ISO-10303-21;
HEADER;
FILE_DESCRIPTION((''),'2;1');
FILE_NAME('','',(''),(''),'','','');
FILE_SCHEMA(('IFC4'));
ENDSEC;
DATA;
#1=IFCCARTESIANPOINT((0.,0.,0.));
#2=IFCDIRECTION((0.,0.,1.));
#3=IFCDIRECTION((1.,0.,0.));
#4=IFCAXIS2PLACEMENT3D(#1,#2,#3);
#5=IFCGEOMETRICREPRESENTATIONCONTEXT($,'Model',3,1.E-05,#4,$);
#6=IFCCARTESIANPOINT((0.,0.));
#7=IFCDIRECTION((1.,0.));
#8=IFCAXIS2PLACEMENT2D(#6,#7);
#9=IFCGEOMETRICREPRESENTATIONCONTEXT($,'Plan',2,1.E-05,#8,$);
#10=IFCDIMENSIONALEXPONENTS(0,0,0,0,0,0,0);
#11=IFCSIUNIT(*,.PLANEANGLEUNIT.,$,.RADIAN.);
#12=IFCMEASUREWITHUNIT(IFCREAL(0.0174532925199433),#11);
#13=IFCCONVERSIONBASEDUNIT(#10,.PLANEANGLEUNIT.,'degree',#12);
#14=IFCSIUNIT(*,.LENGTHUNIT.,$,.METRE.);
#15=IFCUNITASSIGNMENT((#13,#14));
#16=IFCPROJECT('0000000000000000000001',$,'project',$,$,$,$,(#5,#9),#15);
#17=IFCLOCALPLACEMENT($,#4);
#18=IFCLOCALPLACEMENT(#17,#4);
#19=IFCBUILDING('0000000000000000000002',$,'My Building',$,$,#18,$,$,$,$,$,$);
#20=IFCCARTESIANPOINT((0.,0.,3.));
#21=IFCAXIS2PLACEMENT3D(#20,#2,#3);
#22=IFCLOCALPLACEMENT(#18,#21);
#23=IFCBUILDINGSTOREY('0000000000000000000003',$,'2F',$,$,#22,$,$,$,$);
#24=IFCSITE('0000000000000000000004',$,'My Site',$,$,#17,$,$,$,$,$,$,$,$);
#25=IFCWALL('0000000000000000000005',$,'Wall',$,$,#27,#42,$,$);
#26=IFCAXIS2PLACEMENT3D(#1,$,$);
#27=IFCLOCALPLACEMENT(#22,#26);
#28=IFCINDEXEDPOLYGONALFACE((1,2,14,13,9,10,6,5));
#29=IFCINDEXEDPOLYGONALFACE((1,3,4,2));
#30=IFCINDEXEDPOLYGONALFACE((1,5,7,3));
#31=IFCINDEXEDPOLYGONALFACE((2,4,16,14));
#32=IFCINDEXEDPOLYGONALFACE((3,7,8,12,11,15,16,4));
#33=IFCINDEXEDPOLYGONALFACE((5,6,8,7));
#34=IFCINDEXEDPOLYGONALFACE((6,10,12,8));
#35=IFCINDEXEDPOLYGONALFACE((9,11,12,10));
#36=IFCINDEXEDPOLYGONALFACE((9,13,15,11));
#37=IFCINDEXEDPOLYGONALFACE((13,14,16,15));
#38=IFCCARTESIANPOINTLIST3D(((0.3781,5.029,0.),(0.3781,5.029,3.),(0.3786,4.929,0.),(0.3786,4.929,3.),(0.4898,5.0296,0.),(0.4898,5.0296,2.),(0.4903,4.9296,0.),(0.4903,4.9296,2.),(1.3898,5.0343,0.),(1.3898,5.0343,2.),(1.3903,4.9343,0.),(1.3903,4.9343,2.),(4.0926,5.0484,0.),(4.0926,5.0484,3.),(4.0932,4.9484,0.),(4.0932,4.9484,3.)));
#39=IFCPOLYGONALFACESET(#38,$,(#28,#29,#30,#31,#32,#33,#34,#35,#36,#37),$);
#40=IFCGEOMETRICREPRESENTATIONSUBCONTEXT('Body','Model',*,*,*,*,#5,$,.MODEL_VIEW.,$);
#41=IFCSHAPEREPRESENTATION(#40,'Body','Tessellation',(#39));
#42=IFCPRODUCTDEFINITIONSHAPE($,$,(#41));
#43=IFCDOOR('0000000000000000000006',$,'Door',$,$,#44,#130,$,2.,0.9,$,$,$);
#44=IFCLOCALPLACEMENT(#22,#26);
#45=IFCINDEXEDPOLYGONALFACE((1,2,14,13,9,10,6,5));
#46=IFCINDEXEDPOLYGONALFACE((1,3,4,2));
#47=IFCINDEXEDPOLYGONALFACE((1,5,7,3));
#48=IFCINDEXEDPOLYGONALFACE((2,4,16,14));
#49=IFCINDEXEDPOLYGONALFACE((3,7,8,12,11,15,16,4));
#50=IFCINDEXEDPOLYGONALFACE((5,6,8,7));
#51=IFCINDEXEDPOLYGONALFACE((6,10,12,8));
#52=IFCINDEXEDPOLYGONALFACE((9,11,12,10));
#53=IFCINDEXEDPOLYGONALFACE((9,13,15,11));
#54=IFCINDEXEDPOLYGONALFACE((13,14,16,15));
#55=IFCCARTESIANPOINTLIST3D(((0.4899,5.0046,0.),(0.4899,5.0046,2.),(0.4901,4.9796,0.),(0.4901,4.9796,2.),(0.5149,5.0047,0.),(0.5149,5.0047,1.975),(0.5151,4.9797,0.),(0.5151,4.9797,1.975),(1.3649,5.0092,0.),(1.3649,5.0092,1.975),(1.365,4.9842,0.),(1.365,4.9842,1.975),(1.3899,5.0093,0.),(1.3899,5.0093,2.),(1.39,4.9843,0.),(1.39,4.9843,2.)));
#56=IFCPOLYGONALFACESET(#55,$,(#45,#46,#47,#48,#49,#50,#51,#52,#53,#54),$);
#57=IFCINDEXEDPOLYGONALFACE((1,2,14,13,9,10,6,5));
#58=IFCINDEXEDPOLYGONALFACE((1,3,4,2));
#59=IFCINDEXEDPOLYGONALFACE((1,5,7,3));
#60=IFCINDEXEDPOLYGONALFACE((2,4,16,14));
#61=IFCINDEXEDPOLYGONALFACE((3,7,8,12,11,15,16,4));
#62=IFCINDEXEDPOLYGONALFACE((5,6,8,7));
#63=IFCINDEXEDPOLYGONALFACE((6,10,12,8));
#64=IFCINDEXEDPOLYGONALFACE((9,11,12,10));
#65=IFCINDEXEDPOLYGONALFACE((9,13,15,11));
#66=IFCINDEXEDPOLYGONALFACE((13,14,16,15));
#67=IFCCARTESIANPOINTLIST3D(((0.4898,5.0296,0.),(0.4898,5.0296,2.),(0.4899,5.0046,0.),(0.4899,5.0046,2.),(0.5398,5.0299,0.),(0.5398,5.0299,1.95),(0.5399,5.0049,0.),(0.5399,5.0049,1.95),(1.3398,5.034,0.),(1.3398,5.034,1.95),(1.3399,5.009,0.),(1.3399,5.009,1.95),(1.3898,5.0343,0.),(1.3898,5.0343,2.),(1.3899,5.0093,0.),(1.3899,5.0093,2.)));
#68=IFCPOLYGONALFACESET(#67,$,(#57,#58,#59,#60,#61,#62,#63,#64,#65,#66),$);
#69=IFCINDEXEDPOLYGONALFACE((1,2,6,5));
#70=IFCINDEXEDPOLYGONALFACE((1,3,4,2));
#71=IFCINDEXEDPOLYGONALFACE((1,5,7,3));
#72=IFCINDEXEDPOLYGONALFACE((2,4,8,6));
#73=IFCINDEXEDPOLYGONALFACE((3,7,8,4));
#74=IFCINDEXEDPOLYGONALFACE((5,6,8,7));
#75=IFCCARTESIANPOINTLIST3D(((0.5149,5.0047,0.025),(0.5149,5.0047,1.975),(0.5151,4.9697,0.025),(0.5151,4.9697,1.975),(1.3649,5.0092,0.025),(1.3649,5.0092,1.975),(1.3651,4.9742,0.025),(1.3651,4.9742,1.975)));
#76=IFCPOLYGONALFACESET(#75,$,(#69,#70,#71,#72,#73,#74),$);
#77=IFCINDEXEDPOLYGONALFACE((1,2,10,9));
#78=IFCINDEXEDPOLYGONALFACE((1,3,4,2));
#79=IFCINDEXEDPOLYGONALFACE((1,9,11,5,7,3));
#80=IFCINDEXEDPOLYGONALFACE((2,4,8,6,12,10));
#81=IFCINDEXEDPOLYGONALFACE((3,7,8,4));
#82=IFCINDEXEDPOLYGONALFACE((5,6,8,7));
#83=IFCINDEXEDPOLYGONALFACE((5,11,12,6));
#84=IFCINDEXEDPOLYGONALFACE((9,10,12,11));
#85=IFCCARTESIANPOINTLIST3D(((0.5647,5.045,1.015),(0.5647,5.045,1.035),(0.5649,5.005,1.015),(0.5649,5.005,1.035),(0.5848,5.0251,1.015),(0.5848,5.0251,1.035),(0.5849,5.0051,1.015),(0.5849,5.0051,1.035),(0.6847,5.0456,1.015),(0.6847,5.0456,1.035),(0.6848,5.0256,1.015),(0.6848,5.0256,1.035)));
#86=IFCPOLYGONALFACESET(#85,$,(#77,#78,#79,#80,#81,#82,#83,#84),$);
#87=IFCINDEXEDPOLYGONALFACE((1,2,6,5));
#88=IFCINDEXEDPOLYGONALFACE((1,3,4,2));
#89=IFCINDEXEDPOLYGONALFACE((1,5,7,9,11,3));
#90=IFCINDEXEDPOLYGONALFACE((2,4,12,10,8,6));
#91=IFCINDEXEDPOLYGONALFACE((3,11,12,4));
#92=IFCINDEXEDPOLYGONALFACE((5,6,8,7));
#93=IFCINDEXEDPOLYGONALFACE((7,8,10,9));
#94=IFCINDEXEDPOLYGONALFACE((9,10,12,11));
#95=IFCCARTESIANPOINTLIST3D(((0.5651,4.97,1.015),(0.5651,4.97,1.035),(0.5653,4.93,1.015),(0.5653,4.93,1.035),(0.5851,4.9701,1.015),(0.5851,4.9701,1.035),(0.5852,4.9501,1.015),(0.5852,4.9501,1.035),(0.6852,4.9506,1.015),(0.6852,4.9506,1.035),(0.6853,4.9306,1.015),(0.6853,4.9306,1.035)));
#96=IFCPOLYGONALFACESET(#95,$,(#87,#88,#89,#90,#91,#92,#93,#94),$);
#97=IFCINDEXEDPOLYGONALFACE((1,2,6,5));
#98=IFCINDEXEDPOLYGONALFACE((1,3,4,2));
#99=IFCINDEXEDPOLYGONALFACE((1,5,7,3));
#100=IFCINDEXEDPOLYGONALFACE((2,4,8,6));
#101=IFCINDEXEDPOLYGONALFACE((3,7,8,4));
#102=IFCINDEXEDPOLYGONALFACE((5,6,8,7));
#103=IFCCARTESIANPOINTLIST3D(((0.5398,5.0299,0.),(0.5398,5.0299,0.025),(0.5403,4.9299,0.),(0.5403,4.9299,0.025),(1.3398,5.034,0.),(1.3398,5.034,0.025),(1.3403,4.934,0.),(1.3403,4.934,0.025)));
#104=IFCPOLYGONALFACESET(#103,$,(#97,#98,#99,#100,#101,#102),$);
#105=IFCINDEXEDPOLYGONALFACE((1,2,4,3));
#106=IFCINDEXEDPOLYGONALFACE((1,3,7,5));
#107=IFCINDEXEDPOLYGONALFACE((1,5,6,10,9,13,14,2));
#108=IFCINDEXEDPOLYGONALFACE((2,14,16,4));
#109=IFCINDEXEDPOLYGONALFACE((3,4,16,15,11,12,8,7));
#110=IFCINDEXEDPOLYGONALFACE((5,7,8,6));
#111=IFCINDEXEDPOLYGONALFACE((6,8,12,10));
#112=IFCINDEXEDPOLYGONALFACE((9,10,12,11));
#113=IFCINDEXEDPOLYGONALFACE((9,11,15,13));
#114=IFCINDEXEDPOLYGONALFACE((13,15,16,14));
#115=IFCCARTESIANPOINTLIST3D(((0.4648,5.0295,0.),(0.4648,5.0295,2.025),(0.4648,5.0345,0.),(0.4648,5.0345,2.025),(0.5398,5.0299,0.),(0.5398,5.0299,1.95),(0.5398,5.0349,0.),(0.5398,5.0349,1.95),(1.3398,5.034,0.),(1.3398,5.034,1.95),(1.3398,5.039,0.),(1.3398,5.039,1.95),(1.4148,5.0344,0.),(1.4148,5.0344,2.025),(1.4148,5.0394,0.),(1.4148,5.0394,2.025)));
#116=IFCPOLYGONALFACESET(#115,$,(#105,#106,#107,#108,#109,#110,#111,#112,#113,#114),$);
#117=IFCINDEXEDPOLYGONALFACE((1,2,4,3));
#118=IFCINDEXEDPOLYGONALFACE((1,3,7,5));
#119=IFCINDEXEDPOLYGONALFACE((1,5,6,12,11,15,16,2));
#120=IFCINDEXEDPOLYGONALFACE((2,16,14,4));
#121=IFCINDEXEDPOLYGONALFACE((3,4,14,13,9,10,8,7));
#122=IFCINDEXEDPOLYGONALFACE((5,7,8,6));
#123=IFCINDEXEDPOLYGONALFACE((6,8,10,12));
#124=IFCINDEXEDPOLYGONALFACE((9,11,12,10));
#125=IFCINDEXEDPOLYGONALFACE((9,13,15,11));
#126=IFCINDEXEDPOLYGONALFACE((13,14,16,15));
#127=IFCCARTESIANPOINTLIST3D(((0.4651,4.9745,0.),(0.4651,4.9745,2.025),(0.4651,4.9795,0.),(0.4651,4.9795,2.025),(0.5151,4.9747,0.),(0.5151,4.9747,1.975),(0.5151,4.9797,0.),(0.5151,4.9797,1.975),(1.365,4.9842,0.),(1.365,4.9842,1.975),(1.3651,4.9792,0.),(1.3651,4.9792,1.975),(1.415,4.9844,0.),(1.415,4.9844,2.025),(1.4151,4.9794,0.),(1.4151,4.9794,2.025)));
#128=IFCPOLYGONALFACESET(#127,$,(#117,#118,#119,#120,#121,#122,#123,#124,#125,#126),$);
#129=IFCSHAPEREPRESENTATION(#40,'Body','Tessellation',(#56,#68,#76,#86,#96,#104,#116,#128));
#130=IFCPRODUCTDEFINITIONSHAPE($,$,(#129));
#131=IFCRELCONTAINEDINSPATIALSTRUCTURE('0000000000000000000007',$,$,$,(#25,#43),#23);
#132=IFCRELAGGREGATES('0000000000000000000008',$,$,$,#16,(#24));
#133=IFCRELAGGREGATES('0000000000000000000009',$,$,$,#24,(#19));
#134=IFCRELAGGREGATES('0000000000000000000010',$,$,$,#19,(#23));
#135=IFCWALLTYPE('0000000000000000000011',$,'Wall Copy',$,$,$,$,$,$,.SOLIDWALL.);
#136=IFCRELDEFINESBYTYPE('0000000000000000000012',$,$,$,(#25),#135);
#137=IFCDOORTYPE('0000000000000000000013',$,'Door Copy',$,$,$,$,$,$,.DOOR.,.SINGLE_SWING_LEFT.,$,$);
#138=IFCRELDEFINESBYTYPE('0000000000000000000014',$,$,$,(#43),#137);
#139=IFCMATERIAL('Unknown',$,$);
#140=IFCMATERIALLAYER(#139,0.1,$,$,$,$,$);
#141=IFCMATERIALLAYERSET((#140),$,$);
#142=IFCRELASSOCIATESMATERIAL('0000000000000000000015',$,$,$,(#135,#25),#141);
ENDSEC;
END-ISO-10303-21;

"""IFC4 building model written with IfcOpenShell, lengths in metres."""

from ifc_helpers import new_model, entity, si_unit, converted_unit, frame, origin_with_axes, origin_2d_with_axis, place, context, subcontext, project, spatial, line, indexed_curve, outline, extrude, shape, source, transform, mapped, material, layer, layer_set, layer_usage, type_object, type_shapes, element, fill, save


model = new_model("IFC4")

# Units and contexts
model_context = context("Model", 3, precision=1e-05, world=origin_with_axes())
plan_context = context("Plan", 2, precision=1e-05, world=origin_2d_with_axis())
body_context_1 = subcontext(model_context, "Body", "Model", "MODEL_VIEW")
body_context_2 = subcontext(plan_context, "Body", "Plan", "PLAN_VIEW")
ifc_project = project(units=[converted_unit("PLANEANGLEUNIT", "degree", entity("IfcReal", 0.0174532925199433), si_unit("PLANEANGLEUNIT", "RADIAN"), dimensions=[0, 0, 0, 0, 0, 0, 0]), si_unit("LENGTHUNIT", "METRE")], contexts=[model_context, plan_context])

# Site, building, storey
site_placement = place(None, origin_with_axes())
site = spatial("IfcSite", under=ifc_project, at=site_placement, Name="My Site")
building_placement = place(site_placement, origin_with_axes())
building = spatial("IfcBuilding", under=site, at=building_placement, Name="My Building")
storey_placement = place(building_placement, frame((0.0, 0.0, 3.0), z_axis=(0.0, 0.0, 1.0), x_axis=(1.0, 0.0, 0.0)))
storey = spatial("IfcBuildingStorey", under=building, at=storey_placement, Name="2F")

# Shared definitions
ifc_material = material(Name="Unknown")
ifc_layer_1 = layer(ifc_material, 0.1)
ifc_layer_set_1 = layer_set([ifc_layer_1])
wall_type_1 = type_object("IfcWallType", Name="Wall Copy", PredefinedType="SOLIDWALL", material=ifc_layer_set_1)

# Shared definitions
shared_shape_1 = source(origin_with_axes(), body_context_1, "Body", "SweptSolid", [
    extrude(outline(indexed_curve([(0.0, 0.0), (0.9, 0.0), (0.9, 2.0), (0.0, 2.0)], segments=[line(1, 2, 3, 4, 1)])), frame((0.0, -0.6, 0.0), z_axis=(0.0, -1.0, 0.0), x_axis=(1.0, 0.0, 0.0)), (0.0, 0.0, -1.0), 1.2),
])
door_type = type_object("IfcDoorType", Name="Door Copy", OperationType="SINGLE_SWING_LEFT", PredefinedType="DOOR")
shared_shape_2 = source(origin_with_axes(), body_context_1, "Body", "SweptSolid", [
    extrude(outline(indexed_curve([(0.0, 0.0), (0.0, 2.0), (0.9, 2.0), (0.9, 0.0), (0.875, 0.0), (0.875, 1.975), (0.025, 1.975), (0.025, 0.0)], segments=[line(1, 2, 3, 4, 5, 6, 7, 8, 1)])), frame((0.0, 0.025, 0.0), z_axis=(0.0, -1.0, 0.0), x_axis=(1.0, 0.0, 0.0)), (0.0, 0.0, -1.0), 0.025),
    extrude(outline(indexed_curve([(0.0, 0.0), (0.0, 2.0), (0.9, 2.0), (0.9, 0.0), (0.85, 0.0), (0.85, 1.95), (0.05, 1.95), (0.05, 0.0)], segments=[line(1, 2, 3, 4, 5, 6, 7, 8, 1)])), frame((0.0, 0.0, 0.0), z_axis=(0.0, -1.0, 0.0), x_axis=(1.0, 0.0, 0.0)), (0.0, 0.0, -1.0), 0.025),
    extrude(outline(indexed_curve([(0.0, 0.0), (0.85, 0.0), (0.85, 0.035), (0.0, 0.035)], segments=[line(1, 2, 3, 4, 1)])), frame((0.025, 0.025, 0.025), z_axis=(0.0, 0.0, 1.0), x_axis=(1.0, 0.0, 0.0)), (0.0, 0.0, 1.0), 1.95),
    extrude(outline(indexed_curve([(0.0, 0.0), (0.0, -0.04), (-0.12, -0.04), (-0.12, -0.02), (-0.02, -0.02), (-0.02, 0.0)], segments=[line(1, 2, 3, 4, 5, 6, 1)])), frame((0.825, 0.025, 1.015), z_axis=(0.0, 0.0, 1.0), x_axis=(1.0, 0.0, 0.0)), (0.0, 0.0, 1.0), 0.02),
    extrude(outline(indexed_curve([(0.0, 0.0), (0.0, 0.04), (-0.12, 0.04), (-0.12, 0.02), (-0.02, 0.02), (-0.02, 0.0)], segments=[line(1, 2, 3, 4, 5, 6, 1)])), frame((0.825, 0.06, 1.015), z_axis=(0.0, 0.0, 1.0), x_axis=(1.0, 0.0, 0.0)), (0.0, 0.0, 1.0), 0.02),
    extrude(outline(indexed_curve([(0.0, 0.0), (0.8, 0.0), (0.8, 0.1), (0.0, 0.1)], segments=[line(1, 2, 3, 4, 1)])), frame((0.05, 0.0, 0.0), z_axis=(0.0, 0.0, 1.0), x_axis=(1.0, 0.0, 0.0)), (0.0, 0.0, 1.0), 0.025),
    extrude(outline(indexed_curve([(0.0, 0.0), (0.0, 2.025), (0.95, 2.025), (0.95, 0.0), (0.875, 0.0), (0.875, 1.95), (0.075, 1.95), (0.075, 0.0)], segments=[line(1, 2, 3, 4, 5, 6, 7, 8, 1)])), frame((-0.025, -0.005, 0.0), z_axis=(0.0, -1.0, 0.0), x_axis=(1.0, 0.0, 0.0)), (0.0, 0.0, -1.0), 0.005),
    extrude(outline(indexed_curve([(0.0, 0.0), (0.0, 2.025), (0.95, 2.025), (0.95, 0.0), (0.9, 0.0), (0.9, 1.975), (0.05, 1.975), (0.05, 0.0)], segments=[line(1, 2, 3, 4, 5, 6, 7, 8, 1)])), frame((-0.025, 0.05, 0.0), z_axis=(0.0, -1.0, 0.0), x_axis=(1.0, 0.0, 0.0)), (0.0, 0.0, -1.0), 0.005),
])
shared_shape_3 = source(origin_with_axes(), body_context_2, "Body", "Curve2D", [
    entity("IfcIndexedPolyCurve", entity("IfcCartesianPointList2D", [[0.0, 0.0], [0.0, 0.05], [0.025, 0.05], [0.025, 0.025], [0.05, 0.025], [0.05, 0.0]]), [entity("IfcLineIndex", [1, 2, 3, 4, 5, 6, 1])]),
    entity("IfcIndexedPolyCurve", entity("IfcCartesianPointList2D", [[0.9, 0.0], [0.9, 0.05], [0.875, 0.05], [0.875, 0.025], [0.85, 0.025], [0.85, 0.0]]), [entity("IfcLineIndex", [1, 2, 3, 4, 5, 6, 1])]),
    entity("IfcTrimmedCurve", entity("IfcEllipse", entity("IfcAxis2Placement2D", entity("IfcCartesianPoint", [0.06, 0.05]), entity("IfcDirection", [1.0, 0.0])), 0.815, 0.85), [entity("IfcCartesianPoint", [0.875, 0.05])], [entity("IfcCartesianPoint", [0.06, 0.9])], True, "CARTESIAN"),
    entity("IfcIndexedPolyCurve", entity("IfcCartesianPointList2D", [[0.025, 0.05], [0.06, 0.05], [0.06, 0.9], [0.025, 0.9]]), [entity("IfcLineIndex", [1, 2, 3, 4, 1])]),
])
type_shapes(door_type, [shared_shape_2, shared_shape_3])

# Wall, opening, door
ifc_layer_usage_1 = layer_usage(ifc_layer_set_1, "AXIS2", "POSITIVE", 0.0)
wall_1_placement = place(storey_placement, frame((4.0926, 5.0484, 0.0), z_axis=(0.0, 0.0, 1.0), x_axis=(-0.999986, -0.005221, 0.0)))
wall_1 = element("IfcWall", 1, at=wall_1_placement, inside=storey, type_object=wall_type_1, material=ifc_layer_usage_1, Name="Wall", context=body_context_1, shape_type="SweptSolid", body=[
    extrude(outline(indexed_curve([(0.0, 0.0), (0.0, 0.1), (3.7146, 0.1), (3.7146, 0.0)], segments=[line(1, 2, 3, 4, 1)])), origin_with_axes(), (0.0, 0.0, 1.0), 3.0),
])
opening_1_placement = place(wall_1_placement, frame((2.7029, 0.0, 0.0), z_axis=(0.0, 0.0, 1.0), x_axis=(1.0, 0.0, 0.0)))
opening_1 = element("IfcOpeningElement", 2, at=opening_1_placement, cuts=wall_1, PredefinedType="OPENING", context=body_context_1, shape_type="MappedRepresentation", body=[
    mapped(shared_shape_1, transform((0.0, 0.0, 0.0), x_axis=(1.0, 0.0, 0.0), y_axis=(0.0, 1.0, 0.0), z_axis=(0.0, 0.0, 1.0), scale=1.0)),
])
door_1_placement = place(opening_1_placement, origin_with_axes())
door_1 = element("IfcDoor", 3, at=door_1_placement, inside=storey, type_object=door_type, Name="Door", OverallHeight=2.0, OverallWidth=0.9, shapes=[
    shape(body_context_1, "Body", "MappedRepresentation", [mapped(shared_shape_2, transform((0.0, 0.0, 0.0), x_axis=(1.0, 0.0, 0.0), y_axis=(0.0, 1.0, 0.0), z_axis=(0.0, 0.0, 1.0), scale=1.0))]),
    shape(body_context_2, "Body", "MappedRepresentation", [mapped(shared_shape_3, transform((0.0, 0.0, 0.0), x_axis=(1.0, 0.0, 0.0), y_axis=(0.0, 1.0, 0.0), z_axis=(0.0, 0.0, 1.0), scale=1.0))]),
])
fill(opening_1, door_1)

save(model, "model.ifc")
